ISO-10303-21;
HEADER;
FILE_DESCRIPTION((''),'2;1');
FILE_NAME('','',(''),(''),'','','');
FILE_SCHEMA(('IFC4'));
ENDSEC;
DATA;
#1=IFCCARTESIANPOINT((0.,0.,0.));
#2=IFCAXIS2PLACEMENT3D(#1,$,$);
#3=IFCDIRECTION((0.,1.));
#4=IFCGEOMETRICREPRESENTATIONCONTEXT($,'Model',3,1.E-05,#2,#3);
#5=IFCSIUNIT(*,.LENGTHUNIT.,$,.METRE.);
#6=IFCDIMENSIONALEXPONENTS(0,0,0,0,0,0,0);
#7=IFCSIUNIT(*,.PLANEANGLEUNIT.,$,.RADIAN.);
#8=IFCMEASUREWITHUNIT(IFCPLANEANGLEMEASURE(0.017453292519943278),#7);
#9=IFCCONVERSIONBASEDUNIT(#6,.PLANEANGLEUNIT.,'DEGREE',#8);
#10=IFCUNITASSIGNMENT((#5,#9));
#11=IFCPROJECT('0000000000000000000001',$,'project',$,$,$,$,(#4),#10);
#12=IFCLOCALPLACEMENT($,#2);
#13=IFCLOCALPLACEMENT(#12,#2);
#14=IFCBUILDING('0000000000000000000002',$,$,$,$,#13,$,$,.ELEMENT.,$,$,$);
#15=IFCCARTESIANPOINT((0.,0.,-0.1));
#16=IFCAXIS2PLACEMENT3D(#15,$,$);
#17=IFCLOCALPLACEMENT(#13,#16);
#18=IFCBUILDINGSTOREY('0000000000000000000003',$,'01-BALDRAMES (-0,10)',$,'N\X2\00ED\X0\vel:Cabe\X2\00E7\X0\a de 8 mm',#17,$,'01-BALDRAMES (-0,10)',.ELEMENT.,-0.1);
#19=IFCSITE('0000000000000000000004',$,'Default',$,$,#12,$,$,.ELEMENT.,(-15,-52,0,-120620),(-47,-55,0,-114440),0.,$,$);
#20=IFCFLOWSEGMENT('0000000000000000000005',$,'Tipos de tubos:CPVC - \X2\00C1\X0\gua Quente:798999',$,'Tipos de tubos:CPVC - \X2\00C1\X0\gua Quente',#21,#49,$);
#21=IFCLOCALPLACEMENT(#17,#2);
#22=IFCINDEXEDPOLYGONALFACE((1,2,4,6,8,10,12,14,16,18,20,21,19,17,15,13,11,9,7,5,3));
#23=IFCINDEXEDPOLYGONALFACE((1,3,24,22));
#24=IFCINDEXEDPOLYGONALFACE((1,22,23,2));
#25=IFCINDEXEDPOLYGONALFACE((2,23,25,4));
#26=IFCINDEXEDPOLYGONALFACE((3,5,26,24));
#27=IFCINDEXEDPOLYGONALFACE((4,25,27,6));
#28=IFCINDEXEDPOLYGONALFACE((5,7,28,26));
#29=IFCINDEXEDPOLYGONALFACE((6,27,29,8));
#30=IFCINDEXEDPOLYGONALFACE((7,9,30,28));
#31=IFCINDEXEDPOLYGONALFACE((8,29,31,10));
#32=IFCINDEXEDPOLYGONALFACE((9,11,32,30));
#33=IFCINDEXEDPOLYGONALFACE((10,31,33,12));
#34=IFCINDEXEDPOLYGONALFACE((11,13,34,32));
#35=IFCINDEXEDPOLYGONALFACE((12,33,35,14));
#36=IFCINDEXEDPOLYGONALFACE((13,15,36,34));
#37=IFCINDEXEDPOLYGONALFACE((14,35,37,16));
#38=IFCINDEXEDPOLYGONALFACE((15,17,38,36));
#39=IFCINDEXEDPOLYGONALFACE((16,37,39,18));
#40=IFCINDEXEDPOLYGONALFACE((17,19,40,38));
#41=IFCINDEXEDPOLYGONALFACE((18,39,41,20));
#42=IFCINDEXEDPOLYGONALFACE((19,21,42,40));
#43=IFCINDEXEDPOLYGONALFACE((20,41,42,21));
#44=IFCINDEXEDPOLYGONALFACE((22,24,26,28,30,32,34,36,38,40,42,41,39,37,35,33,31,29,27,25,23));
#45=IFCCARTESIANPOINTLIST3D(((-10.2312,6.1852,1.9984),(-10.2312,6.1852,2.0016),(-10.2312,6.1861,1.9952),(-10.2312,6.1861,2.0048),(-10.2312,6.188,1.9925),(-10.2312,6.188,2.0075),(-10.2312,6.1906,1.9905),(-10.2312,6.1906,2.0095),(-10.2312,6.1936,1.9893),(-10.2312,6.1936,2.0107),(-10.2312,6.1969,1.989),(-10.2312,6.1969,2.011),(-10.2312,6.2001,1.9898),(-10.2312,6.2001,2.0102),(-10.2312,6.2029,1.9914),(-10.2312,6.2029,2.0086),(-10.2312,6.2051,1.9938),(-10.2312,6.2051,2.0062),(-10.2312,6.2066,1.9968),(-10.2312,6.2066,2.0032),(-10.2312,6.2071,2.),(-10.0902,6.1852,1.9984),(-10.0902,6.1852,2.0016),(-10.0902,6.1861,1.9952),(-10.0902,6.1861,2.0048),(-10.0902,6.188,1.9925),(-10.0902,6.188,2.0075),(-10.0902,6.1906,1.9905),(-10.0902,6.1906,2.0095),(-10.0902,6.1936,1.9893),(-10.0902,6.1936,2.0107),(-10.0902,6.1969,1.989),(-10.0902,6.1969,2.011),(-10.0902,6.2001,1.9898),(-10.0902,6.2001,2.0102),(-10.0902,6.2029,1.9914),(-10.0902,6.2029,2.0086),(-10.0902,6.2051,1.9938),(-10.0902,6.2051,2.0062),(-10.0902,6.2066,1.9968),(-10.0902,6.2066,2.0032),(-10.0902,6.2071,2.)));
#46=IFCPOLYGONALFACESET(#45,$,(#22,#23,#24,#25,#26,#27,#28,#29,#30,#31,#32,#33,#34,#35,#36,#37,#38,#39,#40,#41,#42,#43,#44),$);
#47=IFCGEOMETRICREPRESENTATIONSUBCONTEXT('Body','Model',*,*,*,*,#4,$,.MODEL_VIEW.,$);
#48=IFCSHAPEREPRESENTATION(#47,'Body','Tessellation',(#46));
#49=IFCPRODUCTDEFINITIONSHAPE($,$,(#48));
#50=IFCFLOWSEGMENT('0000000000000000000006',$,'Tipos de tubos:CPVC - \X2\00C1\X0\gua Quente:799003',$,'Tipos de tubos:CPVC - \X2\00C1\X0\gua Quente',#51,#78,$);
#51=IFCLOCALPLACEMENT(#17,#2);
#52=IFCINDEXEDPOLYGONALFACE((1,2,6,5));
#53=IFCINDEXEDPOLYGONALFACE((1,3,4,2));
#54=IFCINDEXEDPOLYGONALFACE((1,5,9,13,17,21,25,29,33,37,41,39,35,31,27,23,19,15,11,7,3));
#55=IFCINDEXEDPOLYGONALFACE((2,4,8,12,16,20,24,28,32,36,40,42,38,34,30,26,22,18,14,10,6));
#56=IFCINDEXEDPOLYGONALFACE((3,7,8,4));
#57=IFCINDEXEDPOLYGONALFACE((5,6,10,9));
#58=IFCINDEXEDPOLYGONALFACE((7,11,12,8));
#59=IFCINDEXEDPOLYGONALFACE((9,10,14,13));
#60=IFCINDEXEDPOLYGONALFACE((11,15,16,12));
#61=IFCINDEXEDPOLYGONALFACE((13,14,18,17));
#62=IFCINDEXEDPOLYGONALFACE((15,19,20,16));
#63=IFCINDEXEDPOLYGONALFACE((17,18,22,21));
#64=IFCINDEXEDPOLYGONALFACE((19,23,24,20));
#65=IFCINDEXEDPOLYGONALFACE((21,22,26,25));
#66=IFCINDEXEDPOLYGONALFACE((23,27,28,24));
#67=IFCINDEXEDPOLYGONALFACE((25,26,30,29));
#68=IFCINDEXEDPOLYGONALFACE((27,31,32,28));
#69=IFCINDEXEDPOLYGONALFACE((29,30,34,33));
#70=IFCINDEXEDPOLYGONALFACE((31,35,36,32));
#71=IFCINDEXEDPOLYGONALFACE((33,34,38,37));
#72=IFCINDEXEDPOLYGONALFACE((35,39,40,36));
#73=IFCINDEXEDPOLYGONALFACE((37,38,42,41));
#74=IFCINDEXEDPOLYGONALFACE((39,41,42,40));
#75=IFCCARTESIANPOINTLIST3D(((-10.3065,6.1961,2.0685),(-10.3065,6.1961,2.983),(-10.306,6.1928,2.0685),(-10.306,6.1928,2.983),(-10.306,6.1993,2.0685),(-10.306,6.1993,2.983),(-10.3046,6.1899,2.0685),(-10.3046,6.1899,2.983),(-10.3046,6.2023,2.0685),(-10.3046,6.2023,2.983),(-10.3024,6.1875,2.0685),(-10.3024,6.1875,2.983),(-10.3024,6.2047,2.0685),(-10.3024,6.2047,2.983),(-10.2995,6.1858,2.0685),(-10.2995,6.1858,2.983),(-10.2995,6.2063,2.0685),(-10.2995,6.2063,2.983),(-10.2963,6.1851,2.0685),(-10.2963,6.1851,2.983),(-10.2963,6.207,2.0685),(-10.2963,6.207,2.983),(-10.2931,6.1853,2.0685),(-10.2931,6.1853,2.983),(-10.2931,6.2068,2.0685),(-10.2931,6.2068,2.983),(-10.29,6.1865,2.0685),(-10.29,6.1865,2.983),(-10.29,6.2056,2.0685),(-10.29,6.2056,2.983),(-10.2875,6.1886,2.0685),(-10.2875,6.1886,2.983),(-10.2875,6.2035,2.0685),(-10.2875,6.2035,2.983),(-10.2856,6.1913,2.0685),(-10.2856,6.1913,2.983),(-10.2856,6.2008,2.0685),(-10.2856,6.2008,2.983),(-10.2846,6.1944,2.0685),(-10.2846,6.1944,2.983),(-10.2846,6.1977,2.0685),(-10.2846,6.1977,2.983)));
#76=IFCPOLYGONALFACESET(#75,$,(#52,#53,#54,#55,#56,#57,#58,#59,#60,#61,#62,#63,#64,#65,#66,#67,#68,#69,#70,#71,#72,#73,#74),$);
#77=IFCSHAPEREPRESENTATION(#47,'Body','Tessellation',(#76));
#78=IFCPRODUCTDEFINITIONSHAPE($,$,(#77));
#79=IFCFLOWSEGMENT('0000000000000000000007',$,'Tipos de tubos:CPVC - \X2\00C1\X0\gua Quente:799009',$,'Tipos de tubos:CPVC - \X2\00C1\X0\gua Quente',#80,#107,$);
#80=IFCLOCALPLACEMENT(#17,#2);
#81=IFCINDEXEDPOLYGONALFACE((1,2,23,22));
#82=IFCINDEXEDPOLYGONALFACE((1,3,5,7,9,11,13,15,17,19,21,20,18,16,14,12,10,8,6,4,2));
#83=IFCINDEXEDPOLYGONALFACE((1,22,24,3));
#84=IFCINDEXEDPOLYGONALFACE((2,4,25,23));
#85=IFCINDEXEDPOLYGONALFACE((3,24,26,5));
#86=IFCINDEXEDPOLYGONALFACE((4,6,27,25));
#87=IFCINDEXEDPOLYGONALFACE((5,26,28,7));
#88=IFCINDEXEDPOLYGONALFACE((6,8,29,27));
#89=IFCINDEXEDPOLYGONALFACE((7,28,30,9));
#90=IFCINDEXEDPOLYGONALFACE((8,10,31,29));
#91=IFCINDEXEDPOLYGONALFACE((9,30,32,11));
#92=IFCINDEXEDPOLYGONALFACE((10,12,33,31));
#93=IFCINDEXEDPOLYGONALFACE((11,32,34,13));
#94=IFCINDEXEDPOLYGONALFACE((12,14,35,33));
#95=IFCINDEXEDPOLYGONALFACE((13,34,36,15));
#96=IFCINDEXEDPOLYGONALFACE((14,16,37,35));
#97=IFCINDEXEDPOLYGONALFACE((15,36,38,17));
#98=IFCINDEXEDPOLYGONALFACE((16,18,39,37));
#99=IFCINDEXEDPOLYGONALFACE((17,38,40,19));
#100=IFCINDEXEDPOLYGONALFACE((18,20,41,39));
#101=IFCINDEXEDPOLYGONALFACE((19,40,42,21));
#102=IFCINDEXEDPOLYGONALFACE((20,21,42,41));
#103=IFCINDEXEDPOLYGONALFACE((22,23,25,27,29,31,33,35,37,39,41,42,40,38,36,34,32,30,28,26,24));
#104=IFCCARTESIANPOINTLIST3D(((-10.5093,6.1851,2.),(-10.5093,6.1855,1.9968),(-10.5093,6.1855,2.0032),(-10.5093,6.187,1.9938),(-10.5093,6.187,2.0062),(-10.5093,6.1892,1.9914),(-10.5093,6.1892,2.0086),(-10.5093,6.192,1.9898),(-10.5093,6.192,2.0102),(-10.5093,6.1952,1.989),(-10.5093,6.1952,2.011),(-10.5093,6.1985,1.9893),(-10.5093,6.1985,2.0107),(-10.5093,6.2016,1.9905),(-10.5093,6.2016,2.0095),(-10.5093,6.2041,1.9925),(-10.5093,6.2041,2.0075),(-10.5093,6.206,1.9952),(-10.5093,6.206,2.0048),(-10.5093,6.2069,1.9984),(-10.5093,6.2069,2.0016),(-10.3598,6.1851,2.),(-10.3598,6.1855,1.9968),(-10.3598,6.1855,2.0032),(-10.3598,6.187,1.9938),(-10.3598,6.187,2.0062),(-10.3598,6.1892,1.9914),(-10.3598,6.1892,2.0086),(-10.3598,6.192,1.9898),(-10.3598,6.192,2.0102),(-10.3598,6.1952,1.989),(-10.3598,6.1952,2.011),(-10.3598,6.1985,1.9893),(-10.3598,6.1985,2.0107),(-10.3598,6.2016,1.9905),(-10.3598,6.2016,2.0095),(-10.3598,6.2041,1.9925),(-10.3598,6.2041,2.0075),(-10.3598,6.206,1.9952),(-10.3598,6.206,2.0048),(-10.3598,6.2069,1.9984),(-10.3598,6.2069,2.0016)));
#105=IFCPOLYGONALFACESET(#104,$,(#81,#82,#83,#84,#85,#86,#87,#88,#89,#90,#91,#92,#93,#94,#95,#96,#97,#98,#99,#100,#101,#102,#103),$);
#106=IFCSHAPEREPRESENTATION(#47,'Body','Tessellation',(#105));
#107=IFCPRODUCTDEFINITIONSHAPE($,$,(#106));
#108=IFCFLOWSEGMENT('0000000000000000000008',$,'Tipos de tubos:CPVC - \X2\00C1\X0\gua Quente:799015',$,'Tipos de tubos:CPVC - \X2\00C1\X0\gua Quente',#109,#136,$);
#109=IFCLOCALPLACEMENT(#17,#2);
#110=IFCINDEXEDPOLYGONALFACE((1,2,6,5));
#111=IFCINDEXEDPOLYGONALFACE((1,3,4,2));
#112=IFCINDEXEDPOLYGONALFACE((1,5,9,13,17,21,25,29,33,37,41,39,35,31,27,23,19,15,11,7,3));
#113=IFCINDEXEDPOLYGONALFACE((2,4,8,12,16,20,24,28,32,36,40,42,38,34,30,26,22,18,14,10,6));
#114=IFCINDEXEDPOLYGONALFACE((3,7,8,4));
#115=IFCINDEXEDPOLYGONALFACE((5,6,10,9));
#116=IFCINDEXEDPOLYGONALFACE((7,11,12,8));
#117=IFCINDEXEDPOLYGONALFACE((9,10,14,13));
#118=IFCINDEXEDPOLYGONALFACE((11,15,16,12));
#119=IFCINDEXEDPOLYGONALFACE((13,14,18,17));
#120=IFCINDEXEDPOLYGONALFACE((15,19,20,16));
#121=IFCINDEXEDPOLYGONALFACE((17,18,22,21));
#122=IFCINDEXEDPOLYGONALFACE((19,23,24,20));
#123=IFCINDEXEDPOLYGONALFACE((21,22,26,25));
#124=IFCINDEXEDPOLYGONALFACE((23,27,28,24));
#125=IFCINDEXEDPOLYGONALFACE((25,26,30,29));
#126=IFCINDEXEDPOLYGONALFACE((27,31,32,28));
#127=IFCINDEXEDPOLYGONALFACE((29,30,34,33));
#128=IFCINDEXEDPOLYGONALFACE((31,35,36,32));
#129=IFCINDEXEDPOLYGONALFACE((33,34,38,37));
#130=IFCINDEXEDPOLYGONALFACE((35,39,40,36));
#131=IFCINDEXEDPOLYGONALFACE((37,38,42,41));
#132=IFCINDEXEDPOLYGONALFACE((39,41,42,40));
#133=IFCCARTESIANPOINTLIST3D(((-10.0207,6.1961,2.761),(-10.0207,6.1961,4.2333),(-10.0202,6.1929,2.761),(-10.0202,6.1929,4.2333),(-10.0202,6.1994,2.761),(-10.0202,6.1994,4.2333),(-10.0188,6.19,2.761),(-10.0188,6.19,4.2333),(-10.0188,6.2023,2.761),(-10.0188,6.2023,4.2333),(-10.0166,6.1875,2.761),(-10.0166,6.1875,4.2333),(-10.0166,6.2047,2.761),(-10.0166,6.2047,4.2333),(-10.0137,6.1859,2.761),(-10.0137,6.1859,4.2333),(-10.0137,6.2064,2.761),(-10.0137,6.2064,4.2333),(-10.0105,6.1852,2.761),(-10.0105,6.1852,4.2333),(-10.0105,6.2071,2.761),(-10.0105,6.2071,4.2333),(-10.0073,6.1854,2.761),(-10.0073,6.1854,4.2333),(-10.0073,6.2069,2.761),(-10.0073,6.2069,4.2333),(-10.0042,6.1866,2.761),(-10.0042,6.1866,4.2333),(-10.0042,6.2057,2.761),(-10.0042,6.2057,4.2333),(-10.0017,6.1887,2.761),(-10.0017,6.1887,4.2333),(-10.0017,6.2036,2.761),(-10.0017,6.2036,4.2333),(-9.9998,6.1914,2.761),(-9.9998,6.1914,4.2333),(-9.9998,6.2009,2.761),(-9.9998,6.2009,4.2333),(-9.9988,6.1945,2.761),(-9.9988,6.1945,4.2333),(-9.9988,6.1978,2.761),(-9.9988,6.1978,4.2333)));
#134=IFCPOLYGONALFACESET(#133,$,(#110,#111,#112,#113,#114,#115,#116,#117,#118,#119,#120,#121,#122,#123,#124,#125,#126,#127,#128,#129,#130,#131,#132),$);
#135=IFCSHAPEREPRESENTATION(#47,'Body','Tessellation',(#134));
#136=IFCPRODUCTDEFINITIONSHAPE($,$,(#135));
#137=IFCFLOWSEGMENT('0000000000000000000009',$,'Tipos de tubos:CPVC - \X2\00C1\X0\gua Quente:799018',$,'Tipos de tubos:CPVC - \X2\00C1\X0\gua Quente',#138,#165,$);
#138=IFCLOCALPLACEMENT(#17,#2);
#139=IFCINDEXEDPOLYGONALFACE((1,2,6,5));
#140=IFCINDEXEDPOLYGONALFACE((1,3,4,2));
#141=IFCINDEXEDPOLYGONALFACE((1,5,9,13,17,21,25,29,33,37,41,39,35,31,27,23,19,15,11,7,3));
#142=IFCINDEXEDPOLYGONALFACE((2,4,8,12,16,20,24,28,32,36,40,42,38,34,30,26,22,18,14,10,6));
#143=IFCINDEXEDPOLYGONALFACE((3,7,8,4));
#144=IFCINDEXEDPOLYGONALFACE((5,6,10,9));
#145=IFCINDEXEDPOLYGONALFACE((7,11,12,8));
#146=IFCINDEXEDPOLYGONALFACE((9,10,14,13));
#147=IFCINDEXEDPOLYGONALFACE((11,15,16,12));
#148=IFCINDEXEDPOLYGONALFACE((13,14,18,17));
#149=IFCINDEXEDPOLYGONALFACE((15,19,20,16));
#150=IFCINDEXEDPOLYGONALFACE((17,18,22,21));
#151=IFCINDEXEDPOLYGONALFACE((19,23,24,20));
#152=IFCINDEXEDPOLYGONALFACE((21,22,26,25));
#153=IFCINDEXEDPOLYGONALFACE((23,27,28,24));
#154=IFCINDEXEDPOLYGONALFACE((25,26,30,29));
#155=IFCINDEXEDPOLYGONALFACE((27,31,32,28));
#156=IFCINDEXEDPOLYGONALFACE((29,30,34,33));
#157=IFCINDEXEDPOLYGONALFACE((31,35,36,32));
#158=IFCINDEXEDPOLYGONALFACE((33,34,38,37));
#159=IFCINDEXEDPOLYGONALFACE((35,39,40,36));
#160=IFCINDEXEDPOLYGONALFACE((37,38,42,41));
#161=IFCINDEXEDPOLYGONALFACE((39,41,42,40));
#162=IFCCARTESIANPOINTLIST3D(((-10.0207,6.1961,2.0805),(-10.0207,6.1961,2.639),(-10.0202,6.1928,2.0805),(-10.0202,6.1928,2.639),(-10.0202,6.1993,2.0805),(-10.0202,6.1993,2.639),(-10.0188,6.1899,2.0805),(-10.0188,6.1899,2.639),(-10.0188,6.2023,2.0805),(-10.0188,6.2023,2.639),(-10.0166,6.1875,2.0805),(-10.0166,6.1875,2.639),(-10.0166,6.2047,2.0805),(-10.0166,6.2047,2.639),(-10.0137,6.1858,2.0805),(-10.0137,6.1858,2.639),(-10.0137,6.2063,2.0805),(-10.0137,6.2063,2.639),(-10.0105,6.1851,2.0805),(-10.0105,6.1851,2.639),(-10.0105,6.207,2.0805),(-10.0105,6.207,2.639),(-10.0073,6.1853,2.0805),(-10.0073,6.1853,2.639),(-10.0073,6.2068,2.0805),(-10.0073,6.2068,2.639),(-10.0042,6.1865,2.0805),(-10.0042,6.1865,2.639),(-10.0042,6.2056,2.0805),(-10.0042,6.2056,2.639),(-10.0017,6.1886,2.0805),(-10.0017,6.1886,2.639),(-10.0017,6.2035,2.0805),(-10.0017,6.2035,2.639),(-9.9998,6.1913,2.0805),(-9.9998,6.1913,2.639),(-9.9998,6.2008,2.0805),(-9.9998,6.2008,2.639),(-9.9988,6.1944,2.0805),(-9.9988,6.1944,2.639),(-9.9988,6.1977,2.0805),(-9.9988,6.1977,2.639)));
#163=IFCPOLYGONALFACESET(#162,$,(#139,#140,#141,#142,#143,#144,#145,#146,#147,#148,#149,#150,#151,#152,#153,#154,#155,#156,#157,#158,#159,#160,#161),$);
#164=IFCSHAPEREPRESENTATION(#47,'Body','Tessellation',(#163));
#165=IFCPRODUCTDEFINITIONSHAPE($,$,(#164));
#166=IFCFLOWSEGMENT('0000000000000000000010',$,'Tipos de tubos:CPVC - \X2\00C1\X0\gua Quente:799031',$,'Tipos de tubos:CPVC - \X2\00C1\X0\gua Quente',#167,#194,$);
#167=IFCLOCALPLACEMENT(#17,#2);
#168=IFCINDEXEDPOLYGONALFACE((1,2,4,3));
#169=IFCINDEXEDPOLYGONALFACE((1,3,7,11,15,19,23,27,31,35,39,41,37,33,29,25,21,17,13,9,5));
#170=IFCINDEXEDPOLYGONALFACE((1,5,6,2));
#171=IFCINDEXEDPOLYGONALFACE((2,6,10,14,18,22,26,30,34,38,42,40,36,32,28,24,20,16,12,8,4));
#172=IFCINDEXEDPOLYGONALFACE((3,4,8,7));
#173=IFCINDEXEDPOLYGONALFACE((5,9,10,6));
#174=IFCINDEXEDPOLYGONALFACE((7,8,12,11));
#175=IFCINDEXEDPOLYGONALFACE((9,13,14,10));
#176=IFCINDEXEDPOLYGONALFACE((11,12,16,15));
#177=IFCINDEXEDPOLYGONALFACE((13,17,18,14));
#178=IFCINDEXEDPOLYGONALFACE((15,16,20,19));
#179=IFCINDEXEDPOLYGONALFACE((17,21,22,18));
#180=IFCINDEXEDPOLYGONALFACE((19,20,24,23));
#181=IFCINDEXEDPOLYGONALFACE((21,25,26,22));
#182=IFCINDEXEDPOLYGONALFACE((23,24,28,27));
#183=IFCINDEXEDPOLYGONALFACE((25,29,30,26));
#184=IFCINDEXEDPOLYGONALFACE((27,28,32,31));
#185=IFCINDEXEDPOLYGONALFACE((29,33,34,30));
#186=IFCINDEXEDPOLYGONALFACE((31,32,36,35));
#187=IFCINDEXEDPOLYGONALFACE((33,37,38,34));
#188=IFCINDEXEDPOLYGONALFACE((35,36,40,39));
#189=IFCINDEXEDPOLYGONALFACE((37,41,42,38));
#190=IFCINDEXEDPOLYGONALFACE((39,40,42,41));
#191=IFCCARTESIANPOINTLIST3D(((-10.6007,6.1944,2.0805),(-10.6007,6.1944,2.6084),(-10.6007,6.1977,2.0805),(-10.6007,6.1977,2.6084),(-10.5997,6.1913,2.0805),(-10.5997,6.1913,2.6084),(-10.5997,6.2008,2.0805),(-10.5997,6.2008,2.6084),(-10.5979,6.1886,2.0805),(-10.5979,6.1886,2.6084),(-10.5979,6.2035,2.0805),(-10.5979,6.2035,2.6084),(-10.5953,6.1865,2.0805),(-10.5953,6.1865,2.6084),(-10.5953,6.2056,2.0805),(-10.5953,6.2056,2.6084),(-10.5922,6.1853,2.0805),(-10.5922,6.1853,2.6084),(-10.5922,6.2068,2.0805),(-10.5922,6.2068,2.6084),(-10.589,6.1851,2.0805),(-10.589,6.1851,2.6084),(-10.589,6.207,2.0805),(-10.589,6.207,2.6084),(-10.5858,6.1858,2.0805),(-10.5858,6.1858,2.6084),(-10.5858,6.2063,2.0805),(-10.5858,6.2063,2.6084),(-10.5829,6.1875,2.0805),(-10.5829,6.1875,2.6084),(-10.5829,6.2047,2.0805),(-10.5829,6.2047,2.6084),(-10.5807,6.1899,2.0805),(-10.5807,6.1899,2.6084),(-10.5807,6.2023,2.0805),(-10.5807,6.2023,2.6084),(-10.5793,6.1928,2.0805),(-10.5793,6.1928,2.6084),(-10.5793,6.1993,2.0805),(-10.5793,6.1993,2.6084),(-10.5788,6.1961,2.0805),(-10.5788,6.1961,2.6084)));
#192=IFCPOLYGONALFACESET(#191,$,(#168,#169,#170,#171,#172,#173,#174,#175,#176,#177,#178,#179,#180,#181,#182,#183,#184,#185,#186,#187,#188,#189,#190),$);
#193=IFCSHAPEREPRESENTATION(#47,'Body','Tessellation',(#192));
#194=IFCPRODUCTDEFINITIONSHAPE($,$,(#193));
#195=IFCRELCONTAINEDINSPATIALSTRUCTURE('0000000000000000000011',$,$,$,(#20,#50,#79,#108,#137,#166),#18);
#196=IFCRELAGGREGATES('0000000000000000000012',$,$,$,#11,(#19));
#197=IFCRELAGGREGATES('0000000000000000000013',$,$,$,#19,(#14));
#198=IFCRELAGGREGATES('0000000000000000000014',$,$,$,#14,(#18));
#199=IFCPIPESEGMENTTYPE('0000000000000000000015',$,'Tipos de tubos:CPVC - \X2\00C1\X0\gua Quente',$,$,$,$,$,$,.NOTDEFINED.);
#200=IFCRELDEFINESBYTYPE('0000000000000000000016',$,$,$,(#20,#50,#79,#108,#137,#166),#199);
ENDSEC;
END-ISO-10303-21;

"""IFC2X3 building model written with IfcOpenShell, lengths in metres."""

from ifc_helpers import new_model, entity, si_unit, converted_unit, direction, frame, frame_2d, origin, origin_2d_with_axis, place, context, subcontext, project, spatial, circle, extrude, type_object, element, save


model = new_model("IFC2X3")

# Units and contexts
model_context = context("Model", 3, precision=1e-05, world=origin(), true_north=direction((0.0, 1.0)))
body_context = subcontext(model_context, "Body", "Model", "MODEL_VIEW")
ifc_project = project(units=[si_unit("LENGTHUNIT", "METRE"), converted_unit("PLANEANGLEUNIT", "DEGREE", entity("IfcPlaneAngleMeasure", 0.017453292519943278), si_unit("PLANEANGLEUNIT", "RADIAN"), dimensions=[0, 0, 0, 0, 0, 0, 0])], contexts=[model_context])

# Site, building, storey
site_placement = place(None, origin())
site = spatial("IfcSite", under=ifc_project, at=site_placement, Name="Default", CompositionType="ELEMENT", RefLatitude=(-15, -52, 0, -120620), RefLongitude=(-47, -55, 0, -114440), RefElevation=0.0)
building_placement = place(site_placement, origin())
building = spatial("IfcBuilding", under=site, at=building_placement, CompositionType="ELEMENT")
storey_placement = place(building_placement, frame((0.0, 0.0, -0.1)))
storey = spatial("IfcBuildingStorey", under=building, at=storey_placement, Name="01-BALDRAMES (-0,10)", ObjectType="Nível:Cabeça de 8 mm", LongName="01-BALDRAMES (-0,10)", CompositionType="ELEMENT", Elevation=-0.1)

# Flow segments
pipe_segment_type_1 = type_object("IfcPipeSegmentType", Name="Tipos de tubos:CPVC - Água Quente", PredefinedType="NOTDEFINED")
flow_segment_1_placement = place(storey_placement, origin())
element("IfcFlowSegment", 1, at=flow_segment_1_placement, inside=storey, type_object=pipe_segment_type_1, Name="Tipos de tubos:CPVC - Água Quente:798999", ObjectType="Tipos de tubos:CPVC - Água Quente", context=body_context, shape_type="SweptSolid", body=[
    extrude(circle(Radius=0.011, at=frame_2d((0.0, 0.0), x_axis=(1.0, 0.0))), frame((-10.2312, 6.1961, 2.0), z_axis=(1.0, 0.0, 0.0), x_axis=(0.0, 1.0, 0.0)), (0.0, 0.0, 1.0), 0.141),
])
flow_segment_2_placement = place(storey_placement, origin())
element("IfcFlowSegment", 2, at=flow_segment_2_placement, inside=storey, type_object=pipe_segment_type_1, Name="Tipos de tubos:CPVC - Água Quente:799003", ObjectType="Tipos de tubos:CPVC - Água Quente", context=body_context, shape_type="SweptSolid", body=[
    extrude(circle(Radius=0.011, at=origin_2d_with_axis()), frame((-10.2955, 6.1961, 2.0685), z_axis=(0.0, 0.0, 1.0), x_axis=(-1.0, 0.0, 0.0)), (0.0, 0.0, 1.0), 0.9145),
])
flow_segment_3_placement = place(storey_placement, origin())
element("IfcFlowSegment", 3, at=flow_segment_3_placement, inside=storey, type_object=pipe_segment_type_1, Name="Tipos de tubos:CPVC - Água Quente:799009", ObjectType="Tipos de tubos:CPVC - Água Quente", context=body_context, shape_type="SweptSolid", body=[
    extrude(circle(Radius=0.011, at=origin_2d_with_axis()), frame((-10.5093, 6.1961, 2.0), z_axis=(1.0, 0.0, 0.0), x_axis=(0.0, -1.0, 0.0)), (0.0, 0.0, 1.0), 0.1495),
])
flow_segment_4_placement = place(storey_placement, origin())
element("IfcFlowSegment", 4, at=flow_segment_4_placement, inside=storey, type_object=pipe_segment_type_1, Name="Tipos de tubos:CPVC - Água Quente:799015", ObjectType="Tipos de tubos:CPVC - Água Quente", context=body_context, shape_type="SweptSolid", body=[
    extrude(circle(Radius=0.011, at=origin_2d_with_axis()), frame((-10.0097, 6.1961, 2.761), z_axis=(0.0, 0.0, 1.0), x_axis=(-1.0, 0.0, 0.0)), (0.0, 0.0, 1.0), 1.4723),
])
flow_segment_5_placement = place(storey_placement, origin())
element("IfcFlowSegment", 5, at=flow_segment_5_placement, inside=storey, type_object=pipe_segment_type_1, Name="Tipos de tubos:CPVC - Água Quente:799018", ObjectType="Tipos de tubos:CPVC - Água Quente", context=body_context, shape_type="SweptSolid", body=[
    extrude(circle(Radius=0.011, at=origin_2d_with_axis()), frame((-10.0097, 6.1961, 2.0805), z_axis=(0.0, 0.0, 1.0), x_axis=(-1.0, 0.0, 0.0)), (0.0, 0.0, 1.0), 0.5585),
])
flow_segment_6_placement = place(storey_placement, origin())
element("IfcFlowSegment", 6, at=flow_segment_6_placement, inside=storey, type_object=pipe_segment_type_1, Name="Tipos de tubos:CPVC - Água Quente:799031", ObjectType="Tipos de tubos:CPVC - Água Quente", context=body_context, shape_type="SweptSolid", body=[
    extrude(circle(Radius=0.011, at=origin_2d_with_axis()), frame((-10.5898, 6.1961, 2.0805)), (0.0, 0.0, 1.0), 0.5279),
])

save(model, "model.ifc")
